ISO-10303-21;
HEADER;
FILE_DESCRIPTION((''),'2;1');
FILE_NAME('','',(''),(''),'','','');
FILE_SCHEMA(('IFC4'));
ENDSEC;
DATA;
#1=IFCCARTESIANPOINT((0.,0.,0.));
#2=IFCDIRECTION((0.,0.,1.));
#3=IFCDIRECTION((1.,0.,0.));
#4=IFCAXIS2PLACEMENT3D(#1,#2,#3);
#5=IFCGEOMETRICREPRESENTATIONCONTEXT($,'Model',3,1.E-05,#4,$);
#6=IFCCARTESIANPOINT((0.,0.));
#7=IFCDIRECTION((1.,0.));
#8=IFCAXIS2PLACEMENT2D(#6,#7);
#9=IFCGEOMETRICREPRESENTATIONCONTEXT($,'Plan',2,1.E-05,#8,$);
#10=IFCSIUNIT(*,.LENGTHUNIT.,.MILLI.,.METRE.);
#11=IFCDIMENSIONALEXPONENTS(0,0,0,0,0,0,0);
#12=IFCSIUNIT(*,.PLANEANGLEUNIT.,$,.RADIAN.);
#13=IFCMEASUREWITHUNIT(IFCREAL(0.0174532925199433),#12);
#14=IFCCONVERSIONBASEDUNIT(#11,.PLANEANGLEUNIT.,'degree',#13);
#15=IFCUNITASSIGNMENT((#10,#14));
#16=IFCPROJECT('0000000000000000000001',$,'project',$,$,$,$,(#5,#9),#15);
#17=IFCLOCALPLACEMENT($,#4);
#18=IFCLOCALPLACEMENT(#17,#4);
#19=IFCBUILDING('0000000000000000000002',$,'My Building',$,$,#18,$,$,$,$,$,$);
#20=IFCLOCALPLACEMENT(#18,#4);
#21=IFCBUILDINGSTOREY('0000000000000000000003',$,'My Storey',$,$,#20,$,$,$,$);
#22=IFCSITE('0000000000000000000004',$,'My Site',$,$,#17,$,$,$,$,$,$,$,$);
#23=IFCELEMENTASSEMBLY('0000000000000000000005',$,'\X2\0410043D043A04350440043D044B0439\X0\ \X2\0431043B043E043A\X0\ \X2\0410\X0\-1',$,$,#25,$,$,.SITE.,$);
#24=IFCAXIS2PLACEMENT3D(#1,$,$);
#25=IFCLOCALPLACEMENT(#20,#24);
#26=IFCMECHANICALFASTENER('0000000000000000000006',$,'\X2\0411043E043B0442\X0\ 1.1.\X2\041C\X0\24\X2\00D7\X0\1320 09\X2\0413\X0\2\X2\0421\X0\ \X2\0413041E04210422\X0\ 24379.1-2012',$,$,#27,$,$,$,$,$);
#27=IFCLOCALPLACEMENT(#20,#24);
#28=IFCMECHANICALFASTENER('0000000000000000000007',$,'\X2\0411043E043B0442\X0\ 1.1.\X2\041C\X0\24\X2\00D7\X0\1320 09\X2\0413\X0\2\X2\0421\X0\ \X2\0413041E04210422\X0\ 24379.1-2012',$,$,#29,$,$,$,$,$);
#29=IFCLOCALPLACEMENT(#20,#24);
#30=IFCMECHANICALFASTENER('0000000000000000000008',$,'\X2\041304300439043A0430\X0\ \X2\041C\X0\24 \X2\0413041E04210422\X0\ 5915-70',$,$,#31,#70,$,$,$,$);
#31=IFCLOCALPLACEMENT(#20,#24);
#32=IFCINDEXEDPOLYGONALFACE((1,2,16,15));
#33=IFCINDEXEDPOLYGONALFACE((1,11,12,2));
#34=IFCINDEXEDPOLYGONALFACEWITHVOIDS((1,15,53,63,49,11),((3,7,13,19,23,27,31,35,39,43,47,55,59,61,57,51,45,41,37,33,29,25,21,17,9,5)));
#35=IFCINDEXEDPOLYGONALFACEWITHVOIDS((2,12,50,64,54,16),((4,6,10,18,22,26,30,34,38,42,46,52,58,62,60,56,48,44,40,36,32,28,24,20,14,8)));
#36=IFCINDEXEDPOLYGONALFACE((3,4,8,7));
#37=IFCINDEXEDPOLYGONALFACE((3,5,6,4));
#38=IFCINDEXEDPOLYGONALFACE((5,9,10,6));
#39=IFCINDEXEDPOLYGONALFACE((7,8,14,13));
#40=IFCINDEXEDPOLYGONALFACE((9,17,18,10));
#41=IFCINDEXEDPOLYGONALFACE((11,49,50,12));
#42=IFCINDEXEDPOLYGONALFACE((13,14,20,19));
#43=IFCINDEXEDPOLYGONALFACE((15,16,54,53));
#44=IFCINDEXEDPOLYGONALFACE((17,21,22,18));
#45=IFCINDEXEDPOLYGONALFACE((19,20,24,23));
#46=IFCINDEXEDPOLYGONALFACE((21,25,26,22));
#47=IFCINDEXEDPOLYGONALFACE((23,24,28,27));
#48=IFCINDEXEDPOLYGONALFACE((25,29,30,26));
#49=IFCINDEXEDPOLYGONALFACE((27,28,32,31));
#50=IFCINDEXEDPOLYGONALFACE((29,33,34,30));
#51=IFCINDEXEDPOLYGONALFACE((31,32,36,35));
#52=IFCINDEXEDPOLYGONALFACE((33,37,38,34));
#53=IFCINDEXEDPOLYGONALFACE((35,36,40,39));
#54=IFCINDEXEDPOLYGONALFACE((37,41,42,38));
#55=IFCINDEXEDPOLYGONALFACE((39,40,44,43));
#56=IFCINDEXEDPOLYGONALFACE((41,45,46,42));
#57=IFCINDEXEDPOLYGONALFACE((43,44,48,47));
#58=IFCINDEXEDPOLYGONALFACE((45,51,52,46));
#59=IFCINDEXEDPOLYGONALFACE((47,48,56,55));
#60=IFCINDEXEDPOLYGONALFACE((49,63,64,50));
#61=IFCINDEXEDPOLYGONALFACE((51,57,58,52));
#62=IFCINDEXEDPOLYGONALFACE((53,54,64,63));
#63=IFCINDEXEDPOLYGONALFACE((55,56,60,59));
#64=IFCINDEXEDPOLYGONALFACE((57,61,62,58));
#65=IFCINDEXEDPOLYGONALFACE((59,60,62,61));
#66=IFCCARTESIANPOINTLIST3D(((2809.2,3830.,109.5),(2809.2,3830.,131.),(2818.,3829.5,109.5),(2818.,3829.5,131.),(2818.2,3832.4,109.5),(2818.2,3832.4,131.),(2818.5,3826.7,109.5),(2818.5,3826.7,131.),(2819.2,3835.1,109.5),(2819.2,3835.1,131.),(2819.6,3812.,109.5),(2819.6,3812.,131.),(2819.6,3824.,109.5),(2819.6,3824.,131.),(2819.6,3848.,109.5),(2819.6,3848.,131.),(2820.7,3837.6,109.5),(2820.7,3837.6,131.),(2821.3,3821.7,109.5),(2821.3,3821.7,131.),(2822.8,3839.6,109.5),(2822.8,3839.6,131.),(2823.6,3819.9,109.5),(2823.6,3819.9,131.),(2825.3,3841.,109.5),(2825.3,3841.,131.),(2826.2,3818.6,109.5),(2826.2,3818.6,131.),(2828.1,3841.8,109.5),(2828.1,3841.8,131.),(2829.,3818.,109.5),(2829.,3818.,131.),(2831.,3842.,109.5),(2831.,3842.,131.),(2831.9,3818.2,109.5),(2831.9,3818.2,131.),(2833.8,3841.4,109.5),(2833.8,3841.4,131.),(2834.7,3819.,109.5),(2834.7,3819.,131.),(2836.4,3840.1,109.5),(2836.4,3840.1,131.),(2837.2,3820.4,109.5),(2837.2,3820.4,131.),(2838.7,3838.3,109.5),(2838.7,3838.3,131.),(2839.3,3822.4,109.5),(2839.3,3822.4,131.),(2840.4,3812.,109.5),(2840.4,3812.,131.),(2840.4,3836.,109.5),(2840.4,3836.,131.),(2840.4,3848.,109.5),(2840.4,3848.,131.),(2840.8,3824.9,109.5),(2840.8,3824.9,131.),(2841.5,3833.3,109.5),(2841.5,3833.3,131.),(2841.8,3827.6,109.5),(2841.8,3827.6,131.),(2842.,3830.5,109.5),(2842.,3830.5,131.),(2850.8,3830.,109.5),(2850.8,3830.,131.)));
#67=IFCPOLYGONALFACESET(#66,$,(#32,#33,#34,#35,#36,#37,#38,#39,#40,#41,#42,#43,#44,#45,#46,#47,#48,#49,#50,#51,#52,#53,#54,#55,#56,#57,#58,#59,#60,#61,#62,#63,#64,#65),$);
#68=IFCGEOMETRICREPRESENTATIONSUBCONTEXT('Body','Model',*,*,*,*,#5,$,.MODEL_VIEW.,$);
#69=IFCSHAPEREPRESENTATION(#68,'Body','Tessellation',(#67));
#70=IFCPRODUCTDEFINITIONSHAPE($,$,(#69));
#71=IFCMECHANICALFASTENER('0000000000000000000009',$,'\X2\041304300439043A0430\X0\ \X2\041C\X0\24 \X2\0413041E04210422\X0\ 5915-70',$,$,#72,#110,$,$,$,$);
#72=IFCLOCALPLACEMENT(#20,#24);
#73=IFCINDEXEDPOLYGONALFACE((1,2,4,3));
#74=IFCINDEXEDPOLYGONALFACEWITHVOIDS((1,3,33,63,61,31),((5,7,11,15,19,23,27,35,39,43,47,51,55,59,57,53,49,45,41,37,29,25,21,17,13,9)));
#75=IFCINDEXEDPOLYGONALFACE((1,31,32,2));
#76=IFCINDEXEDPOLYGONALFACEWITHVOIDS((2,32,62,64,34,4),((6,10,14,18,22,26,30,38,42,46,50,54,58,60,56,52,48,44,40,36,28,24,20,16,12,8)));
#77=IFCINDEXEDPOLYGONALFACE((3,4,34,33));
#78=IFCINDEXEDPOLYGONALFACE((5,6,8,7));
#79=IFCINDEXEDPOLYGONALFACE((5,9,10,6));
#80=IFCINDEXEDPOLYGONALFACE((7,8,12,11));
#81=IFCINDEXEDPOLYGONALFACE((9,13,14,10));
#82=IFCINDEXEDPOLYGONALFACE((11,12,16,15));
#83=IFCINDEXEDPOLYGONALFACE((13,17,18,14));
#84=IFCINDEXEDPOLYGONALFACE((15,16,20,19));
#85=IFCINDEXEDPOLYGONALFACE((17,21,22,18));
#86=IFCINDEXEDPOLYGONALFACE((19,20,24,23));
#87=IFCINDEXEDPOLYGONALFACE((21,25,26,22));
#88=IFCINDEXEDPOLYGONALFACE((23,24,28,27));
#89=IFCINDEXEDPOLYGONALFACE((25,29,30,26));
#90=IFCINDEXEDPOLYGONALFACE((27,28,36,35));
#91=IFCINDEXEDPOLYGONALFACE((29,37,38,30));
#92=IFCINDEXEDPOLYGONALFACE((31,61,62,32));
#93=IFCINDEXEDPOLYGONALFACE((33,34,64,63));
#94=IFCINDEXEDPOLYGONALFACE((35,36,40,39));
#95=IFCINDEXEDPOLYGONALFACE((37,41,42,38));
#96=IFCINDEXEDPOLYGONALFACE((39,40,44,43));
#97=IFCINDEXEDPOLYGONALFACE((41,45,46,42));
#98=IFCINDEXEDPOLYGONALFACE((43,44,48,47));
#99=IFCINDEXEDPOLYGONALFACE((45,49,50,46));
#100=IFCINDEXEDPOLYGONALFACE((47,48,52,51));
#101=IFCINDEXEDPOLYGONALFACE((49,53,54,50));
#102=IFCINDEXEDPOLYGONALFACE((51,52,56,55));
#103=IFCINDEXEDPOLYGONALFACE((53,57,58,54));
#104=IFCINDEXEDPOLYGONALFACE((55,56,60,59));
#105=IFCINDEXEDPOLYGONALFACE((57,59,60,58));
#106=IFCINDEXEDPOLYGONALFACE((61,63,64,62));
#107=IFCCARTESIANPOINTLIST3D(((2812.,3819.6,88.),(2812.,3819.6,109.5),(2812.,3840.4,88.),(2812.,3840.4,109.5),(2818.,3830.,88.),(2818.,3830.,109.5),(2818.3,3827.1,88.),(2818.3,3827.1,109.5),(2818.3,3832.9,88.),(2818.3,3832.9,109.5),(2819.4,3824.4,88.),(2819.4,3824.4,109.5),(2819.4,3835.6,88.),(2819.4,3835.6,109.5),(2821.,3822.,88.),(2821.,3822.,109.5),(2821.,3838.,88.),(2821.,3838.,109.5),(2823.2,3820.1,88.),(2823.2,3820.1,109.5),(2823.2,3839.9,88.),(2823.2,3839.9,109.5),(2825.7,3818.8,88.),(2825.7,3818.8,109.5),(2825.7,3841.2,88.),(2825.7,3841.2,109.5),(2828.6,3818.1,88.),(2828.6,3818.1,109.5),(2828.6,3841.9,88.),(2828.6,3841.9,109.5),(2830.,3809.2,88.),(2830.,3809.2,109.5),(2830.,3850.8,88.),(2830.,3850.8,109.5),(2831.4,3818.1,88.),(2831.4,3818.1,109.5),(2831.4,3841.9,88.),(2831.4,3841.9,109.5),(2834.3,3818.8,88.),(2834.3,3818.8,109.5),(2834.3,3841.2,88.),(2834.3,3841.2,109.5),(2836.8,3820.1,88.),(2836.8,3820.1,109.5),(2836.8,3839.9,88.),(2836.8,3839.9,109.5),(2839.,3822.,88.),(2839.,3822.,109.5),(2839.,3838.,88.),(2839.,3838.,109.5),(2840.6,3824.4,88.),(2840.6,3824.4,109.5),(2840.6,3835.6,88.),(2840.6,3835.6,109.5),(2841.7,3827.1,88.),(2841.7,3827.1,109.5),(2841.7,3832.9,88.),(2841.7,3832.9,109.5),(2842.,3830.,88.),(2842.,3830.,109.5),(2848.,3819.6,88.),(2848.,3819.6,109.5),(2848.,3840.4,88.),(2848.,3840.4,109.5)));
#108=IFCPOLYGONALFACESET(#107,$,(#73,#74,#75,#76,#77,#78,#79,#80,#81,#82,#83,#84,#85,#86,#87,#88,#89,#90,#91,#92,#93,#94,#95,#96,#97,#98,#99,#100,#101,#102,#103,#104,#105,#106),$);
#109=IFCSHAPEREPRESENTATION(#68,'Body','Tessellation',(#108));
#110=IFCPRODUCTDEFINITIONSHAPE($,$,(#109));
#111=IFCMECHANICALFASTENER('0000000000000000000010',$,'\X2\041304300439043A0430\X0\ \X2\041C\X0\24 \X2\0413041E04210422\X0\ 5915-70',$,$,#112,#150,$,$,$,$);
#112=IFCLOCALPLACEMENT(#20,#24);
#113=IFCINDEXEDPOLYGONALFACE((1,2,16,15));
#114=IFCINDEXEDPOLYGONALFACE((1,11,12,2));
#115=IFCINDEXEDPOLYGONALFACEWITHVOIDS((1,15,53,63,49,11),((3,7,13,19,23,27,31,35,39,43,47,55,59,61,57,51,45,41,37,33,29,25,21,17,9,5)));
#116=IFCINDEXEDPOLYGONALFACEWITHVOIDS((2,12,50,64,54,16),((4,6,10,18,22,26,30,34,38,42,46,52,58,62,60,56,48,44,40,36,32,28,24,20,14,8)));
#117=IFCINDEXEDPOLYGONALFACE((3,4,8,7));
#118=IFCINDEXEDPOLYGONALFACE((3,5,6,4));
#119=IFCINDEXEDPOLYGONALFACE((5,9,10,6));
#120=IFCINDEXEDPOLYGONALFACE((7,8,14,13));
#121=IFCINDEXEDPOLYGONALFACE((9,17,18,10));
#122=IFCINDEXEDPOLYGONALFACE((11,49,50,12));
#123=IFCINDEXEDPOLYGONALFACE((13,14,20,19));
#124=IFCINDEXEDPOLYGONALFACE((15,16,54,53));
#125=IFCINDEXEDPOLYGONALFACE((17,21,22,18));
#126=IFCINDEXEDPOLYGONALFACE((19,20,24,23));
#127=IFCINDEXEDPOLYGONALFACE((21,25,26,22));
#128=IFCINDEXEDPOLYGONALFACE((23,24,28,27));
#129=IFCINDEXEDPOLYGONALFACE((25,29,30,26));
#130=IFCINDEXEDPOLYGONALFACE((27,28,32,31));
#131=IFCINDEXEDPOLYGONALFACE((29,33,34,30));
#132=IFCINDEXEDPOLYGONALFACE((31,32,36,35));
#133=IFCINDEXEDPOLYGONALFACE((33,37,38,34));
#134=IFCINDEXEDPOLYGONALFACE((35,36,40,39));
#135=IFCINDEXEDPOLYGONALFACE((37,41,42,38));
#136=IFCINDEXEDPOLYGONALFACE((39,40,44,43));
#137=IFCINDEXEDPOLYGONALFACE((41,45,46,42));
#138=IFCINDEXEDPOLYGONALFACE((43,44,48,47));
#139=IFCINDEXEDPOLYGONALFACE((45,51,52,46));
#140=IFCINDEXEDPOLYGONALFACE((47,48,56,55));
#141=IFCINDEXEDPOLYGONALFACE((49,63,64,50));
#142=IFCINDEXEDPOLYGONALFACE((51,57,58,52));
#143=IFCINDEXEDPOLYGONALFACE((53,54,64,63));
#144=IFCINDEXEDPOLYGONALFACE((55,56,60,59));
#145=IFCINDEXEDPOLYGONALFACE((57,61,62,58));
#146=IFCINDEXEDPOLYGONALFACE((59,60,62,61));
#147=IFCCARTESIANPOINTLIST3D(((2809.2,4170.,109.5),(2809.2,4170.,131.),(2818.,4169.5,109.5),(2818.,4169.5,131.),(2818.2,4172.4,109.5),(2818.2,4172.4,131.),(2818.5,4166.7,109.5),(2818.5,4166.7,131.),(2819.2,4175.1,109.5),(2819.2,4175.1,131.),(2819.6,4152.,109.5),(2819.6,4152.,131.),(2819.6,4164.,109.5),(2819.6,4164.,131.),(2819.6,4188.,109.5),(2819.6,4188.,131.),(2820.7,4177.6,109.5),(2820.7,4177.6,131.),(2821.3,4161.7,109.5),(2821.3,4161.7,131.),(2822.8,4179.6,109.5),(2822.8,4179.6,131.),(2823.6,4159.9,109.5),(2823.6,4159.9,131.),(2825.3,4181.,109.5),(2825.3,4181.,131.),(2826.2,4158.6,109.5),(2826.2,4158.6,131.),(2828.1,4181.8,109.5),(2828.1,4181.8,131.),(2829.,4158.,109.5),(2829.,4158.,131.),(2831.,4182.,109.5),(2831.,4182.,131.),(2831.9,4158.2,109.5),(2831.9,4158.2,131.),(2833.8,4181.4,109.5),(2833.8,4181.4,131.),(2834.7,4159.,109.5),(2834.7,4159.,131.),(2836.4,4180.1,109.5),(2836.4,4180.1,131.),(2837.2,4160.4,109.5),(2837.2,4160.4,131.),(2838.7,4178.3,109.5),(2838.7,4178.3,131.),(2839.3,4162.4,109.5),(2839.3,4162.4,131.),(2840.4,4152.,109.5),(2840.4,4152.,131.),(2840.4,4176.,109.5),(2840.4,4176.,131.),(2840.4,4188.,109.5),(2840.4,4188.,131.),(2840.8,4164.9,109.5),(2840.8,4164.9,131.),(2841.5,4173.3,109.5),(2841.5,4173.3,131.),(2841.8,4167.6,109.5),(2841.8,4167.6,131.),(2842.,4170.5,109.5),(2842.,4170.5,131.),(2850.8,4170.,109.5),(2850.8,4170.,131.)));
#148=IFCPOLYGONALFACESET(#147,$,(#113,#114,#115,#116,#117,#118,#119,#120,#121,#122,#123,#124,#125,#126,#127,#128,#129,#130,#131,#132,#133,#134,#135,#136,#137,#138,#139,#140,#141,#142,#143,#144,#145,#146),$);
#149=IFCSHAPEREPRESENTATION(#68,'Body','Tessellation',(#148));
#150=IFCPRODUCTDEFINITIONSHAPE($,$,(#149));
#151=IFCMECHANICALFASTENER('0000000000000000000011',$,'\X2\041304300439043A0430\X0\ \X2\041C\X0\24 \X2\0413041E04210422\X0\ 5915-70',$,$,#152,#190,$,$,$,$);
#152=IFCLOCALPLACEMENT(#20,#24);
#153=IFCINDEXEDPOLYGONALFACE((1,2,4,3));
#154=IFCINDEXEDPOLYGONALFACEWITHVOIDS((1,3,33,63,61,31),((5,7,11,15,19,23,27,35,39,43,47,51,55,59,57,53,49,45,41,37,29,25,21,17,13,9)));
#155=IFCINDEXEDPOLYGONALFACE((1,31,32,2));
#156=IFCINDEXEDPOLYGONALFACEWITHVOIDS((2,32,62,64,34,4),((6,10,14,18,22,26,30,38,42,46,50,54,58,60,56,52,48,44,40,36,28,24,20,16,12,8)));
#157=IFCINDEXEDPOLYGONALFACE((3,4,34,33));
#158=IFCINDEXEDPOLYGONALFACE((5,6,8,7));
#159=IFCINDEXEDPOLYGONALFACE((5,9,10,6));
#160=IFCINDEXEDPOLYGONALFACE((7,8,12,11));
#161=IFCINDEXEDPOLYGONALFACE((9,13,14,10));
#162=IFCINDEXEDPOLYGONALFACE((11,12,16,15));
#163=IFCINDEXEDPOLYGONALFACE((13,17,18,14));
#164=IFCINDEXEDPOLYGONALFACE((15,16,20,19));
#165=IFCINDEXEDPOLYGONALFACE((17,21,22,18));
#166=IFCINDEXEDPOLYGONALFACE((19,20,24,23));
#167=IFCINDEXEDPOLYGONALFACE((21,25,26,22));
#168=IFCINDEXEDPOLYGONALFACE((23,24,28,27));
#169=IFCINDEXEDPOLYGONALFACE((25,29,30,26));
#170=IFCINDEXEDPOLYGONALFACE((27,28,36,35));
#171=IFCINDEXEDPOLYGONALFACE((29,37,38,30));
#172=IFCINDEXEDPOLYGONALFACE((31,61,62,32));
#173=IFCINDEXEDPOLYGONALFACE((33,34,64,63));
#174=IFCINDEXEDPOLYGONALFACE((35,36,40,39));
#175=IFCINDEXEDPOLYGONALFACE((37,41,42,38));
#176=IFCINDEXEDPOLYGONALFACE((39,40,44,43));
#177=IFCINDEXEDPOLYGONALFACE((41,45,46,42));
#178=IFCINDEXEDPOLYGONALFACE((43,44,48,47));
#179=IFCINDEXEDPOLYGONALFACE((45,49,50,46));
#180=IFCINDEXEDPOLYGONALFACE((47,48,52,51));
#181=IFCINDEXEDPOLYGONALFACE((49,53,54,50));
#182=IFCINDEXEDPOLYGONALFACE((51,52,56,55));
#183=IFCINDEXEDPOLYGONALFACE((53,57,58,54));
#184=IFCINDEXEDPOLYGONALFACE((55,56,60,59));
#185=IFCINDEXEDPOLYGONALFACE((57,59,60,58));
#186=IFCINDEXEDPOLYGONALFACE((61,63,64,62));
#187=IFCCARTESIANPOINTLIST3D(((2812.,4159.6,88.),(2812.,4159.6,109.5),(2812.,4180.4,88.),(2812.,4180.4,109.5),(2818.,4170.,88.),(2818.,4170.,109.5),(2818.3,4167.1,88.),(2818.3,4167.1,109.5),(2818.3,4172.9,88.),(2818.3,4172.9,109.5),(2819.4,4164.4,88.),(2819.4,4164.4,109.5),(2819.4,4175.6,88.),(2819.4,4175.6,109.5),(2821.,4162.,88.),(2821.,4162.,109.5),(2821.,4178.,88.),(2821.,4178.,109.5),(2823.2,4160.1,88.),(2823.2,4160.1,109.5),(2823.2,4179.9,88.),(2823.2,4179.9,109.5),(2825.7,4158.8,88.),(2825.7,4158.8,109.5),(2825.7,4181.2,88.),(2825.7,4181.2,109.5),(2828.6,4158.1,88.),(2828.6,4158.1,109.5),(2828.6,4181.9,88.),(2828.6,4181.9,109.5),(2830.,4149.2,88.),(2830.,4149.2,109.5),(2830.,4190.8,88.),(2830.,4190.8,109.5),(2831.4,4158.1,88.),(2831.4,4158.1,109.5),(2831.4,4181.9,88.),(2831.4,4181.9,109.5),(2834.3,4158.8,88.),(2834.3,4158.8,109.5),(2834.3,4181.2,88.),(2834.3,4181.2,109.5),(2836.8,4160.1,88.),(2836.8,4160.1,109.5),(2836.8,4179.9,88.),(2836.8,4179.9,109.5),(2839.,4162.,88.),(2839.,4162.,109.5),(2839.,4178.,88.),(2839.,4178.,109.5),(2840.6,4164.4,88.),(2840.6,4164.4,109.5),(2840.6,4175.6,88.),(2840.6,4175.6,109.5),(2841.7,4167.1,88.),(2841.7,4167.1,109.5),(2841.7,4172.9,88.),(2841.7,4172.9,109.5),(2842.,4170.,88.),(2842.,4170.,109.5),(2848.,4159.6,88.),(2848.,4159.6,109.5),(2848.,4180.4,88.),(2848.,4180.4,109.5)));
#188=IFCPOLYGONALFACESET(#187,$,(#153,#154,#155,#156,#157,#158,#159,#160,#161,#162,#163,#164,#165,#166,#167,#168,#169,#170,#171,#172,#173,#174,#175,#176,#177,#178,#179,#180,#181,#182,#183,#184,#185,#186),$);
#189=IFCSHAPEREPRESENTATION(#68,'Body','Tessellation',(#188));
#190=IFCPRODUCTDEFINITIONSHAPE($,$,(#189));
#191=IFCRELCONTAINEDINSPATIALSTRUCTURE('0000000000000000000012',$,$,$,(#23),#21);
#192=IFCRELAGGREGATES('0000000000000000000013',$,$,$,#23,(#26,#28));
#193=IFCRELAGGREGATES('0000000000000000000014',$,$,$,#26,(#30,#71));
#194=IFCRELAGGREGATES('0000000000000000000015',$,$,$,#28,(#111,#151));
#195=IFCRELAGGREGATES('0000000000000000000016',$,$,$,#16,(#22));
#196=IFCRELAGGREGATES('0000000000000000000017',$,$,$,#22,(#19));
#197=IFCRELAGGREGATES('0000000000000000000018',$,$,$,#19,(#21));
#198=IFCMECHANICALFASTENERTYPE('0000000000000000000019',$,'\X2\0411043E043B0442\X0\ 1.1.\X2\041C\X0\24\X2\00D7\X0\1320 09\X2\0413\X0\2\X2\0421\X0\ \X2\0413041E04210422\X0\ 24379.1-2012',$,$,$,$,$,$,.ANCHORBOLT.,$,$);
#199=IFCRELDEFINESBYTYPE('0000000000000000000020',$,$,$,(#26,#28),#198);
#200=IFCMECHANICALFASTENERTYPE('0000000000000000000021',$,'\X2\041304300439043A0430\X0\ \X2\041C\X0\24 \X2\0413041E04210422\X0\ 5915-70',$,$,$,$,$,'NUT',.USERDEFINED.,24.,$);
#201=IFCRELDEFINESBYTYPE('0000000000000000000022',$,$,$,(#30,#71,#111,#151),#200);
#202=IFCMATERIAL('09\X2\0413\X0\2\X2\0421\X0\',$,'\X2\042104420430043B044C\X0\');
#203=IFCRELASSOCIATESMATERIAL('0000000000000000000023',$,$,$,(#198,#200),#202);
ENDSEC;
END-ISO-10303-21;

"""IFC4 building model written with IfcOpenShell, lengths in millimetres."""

from ifc_helpers import new_model, entity, si_unit, converted_unit, frame, origin_with_axes, origin_2d_with_axis, place, context, subcontext, project, spatial, polyline, outline, extrude, source, transform, mapped, material, type_object, type_shapes, element, aggregate, save


model = new_model("IFC4")

# Units and contexts
model_context = context("Model", 3, precision=1e-05, world=origin_with_axes())
plan_context = context("Plan", 2, precision=1e-05, world=origin_2d_with_axis())
body_context = subcontext(model_context, "Body", "Model", "MODEL_VIEW")
ifc_project = project(units=[si_unit("LENGTHUNIT", "METRE", prefix="MILLI"), converted_unit("PLANEANGLEUNIT", "degree", entity("IfcReal", 0.0174532925199433), si_unit("PLANEANGLEUNIT", "RADIAN"), dimensions=[0, 0, 0, 0, 0, 0, 0])], contexts=[model_context, plan_context])

# Site, building, storey
site_placement = place(None, origin_with_axes())
site = spatial("IfcSite", under=ifc_project, at=site_placement, Name="My Site")
building_placement = place(site_placement, origin_with_axes())
building = spatial("IfcBuilding", under=site, at=building_placement, Name="My Building")
storey_placement = place(building_placement, origin_with_axes())
storey = spatial("IfcBuildingStorey", under=building, at=storey_placement, Name="My Storey")

# Element assembly, mechanical fasteners
ifc_material_1 = material(Name="09Г2С", Category="Сталь")
mechanical_fastener_type_1 = type_object("IfcMechanicalFastenerType", Name="Болт 1.1.М24×1320 09Г2С ГОСТ 24379.1-2012", PredefinedType="ANCHORBOLT", material=ifc_material_1)
assembly_1_placement = place(storey_placement, frame((3000.0, 4000.0, 0.0), z_axis=(0.0, 0.0, 1.0), x_axis=(1.0, 0.0, 0.0)))
assembly_1 = element("IfcElementAssembly", 1, at=assembly_1_placement, inside=storey, Name="Анкерный блок А-1", AssemblyPlace="SITE")
mechanical_fastener_1_placement = place(assembly_1_placement, frame((-170.0, -170.0, 0.0), z_axis=(0.0, 0.0, 1.0), x_axis=(1.0, 0.0, 0.0)))
mechanical_fastener_1 = element("IfcMechanicalFastener", 2, at=mechanical_fastener_1_placement, type_object=mechanical_fastener_type_1, Name="Болт 1.1.М24×1320 09Г2С ГОСТ 24379.1-2012")
mechanical_fastener_2_placement = place(assembly_1_placement, frame((-170.0, 170.0, 0.0), z_axis=(0.0, 0.0, 1.0), x_axis=(-1.0, 0.0, 0.0)))
mechanical_fastener_2 = element("IfcMechanicalFastener", 3, at=mechanical_fastener_2_placement, type_object=mechanical_fastener_type_1, Name="Болт 1.1.М24×1320 09Г2С ГОСТ 24379.1-2012")
aggregate(assembly_1, [mechanical_fastener_1, mechanical_fastener_2])

# Mechanical fasteners
mechanical_fastener_type_2 = type_object("IfcMechanicalFastenerType", Name="Гайка М24 ГОСТ 5915-70", ElementType="NUT", NominalDiameter=24.0, PredefinedType="USERDEFINED", material=ifc_material_1)
shared_shape_1 = source(origin_with_axes(), body_context, "Body", "SweptSolid", [
    extrude(outline(polyline([(-10.4, -18.0), (10.4, -18.0), (20.8, 0.0), (10.4, 18.0), (-10.4, 18.0), (-20.8, 0.0), (-10.4, -18.0)]), holes=[polyline([(-8.0, 9.0), (-5.6, 10.6), (-2.9, 11.7), (0.0, 12.0), (2.9, 11.7), (5.6, 10.6), (8.0, 9.0), (9.9, 6.8), (11.2, 4.3), (11.9, 1.4), (11.9, -1.4), (11.2, -4.3), (9.9, -6.8), (8.0, -9.0), (5.6, -10.6), (2.9, -11.7), (0.0, -12.0), (-2.9, -11.7), (-5.6, -10.6), (-8.0, -9.0), (-9.9, -6.8), (-11.2, -4.3), (-11.9, -1.4), (-11.9, 1.4), (-11.2, 4.3), (-9.9, 6.8), (-8.0, 9.0)])]), frame((0.0, 0.0, 0.0), z_axis=(0.0, 0.0, 1.0), x_axis=(0.0, 1.0, 0.0)), (0.0, 0.0, 1.0), 21.5),
])
type_shapes(mechanical_fastener_type_2, [shared_shape_1])
mechanical_fastener_3_placement = place(mechanical_fastener_1_placement, frame((0.0, 0.0, 109.5), z_axis=(0.0, 0.0, 1.0), x_axis=(0.866025, 0.5, 0.0)))
mechanical_fastener_3 = element("IfcMechanicalFastener", 4, at=mechanical_fastener_3_placement, type_object=mechanical_fastener_type_2, Name="Гайка М24 ГОСТ 5915-70", context=body_context, shape_type="MappedRepresentation", body=[
    mapped(shared_shape_1, transform((0.0, 0.0, 0.0), x_axis=(1.0, 0.0, 0.0), y_axis=(0.0, 1.0, 0.0), z_axis=(0.0, 0.0, 1.0), scale=1.0)),
])
mechanical_fastener_4_placement = place(mechanical_fastener_1_placement, frame((0.0, 0.0, 88.0), z_axis=(0.0, 0.0, 1.0), x_axis=(1.0, 0.0, 0.0)))
mechanical_fastener_4 = element("IfcMechanicalFastener", 5, at=mechanical_fastener_4_placement, type_object=mechanical_fastener_type_2, Name="Гайка М24 ГОСТ 5915-70", context=body_context, shape_type="MappedRepresentation", body=[
    mapped(shared_shape_1, transform((0.0, 0.0, 0.0), x_axis=(1.0, 0.0, 0.0), y_axis=(0.0, 1.0, 0.0), z_axis=(0.0, 0.0, 1.0), scale=1.0)),
])
mechanical_fastener_5_placement = place(mechanical_fastener_2_placement, frame((0.0, 0.0, 109.5), z_axis=(0.0, 0.0, 1.0), x_axis=(0.866025, 0.5, 0.0)))
mechanical_fastener_5 = element("IfcMechanicalFastener", 6, at=mechanical_fastener_5_placement, type_object=mechanical_fastener_type_2, Name="Гайка М24 ГОСТ 5915-70", context=body_context, shape_type="MappedRepresentation", body=[
    mapped(shared_shape_1, transform((0.0, 0.0, 0.0), x_axis=(1.0, 0.0, 0.0), y_axis=(0.0, 1.0, 0.0), z_axis=(0.0, 0.0, 1.0), scale=1.0)),
])
mechanical_fastener_6_placement = place(mechanical_fastener_2_placement, frame((0.0, 0.0, 88.0), z_axis=(0.0, 0.0, 1.0), x_axis=(1.0, 0.0, 0.0)))
mechanical_fastener_6 = element("IfcMechanicalFastener", 7, at=mechanical_fastener_6_placement, type_object=mechanical_fastener_type_2, Name="Гайка М24 ГОСТ 5915-70", context=body_context, shape_type="MappedRepresentation", body=[
    mapped(shared_shape_1, transform((0.0, 0.0, 0.0), x_axis=(1.0, 0.0, 0.0), y_axis=(0.0, 1.0, 0.0), z_axis=(0.0, 0.0, 1.0), scale=1.0)),
])
aggregate(mechanical_fastener_1, [mechanical_fastener_3, mechanical_fastener_4])
aggregate(mechanical_fastener_2, [mechanical_fastener_5, mechanical_fastener_6])

save(model, "model.ifc")
